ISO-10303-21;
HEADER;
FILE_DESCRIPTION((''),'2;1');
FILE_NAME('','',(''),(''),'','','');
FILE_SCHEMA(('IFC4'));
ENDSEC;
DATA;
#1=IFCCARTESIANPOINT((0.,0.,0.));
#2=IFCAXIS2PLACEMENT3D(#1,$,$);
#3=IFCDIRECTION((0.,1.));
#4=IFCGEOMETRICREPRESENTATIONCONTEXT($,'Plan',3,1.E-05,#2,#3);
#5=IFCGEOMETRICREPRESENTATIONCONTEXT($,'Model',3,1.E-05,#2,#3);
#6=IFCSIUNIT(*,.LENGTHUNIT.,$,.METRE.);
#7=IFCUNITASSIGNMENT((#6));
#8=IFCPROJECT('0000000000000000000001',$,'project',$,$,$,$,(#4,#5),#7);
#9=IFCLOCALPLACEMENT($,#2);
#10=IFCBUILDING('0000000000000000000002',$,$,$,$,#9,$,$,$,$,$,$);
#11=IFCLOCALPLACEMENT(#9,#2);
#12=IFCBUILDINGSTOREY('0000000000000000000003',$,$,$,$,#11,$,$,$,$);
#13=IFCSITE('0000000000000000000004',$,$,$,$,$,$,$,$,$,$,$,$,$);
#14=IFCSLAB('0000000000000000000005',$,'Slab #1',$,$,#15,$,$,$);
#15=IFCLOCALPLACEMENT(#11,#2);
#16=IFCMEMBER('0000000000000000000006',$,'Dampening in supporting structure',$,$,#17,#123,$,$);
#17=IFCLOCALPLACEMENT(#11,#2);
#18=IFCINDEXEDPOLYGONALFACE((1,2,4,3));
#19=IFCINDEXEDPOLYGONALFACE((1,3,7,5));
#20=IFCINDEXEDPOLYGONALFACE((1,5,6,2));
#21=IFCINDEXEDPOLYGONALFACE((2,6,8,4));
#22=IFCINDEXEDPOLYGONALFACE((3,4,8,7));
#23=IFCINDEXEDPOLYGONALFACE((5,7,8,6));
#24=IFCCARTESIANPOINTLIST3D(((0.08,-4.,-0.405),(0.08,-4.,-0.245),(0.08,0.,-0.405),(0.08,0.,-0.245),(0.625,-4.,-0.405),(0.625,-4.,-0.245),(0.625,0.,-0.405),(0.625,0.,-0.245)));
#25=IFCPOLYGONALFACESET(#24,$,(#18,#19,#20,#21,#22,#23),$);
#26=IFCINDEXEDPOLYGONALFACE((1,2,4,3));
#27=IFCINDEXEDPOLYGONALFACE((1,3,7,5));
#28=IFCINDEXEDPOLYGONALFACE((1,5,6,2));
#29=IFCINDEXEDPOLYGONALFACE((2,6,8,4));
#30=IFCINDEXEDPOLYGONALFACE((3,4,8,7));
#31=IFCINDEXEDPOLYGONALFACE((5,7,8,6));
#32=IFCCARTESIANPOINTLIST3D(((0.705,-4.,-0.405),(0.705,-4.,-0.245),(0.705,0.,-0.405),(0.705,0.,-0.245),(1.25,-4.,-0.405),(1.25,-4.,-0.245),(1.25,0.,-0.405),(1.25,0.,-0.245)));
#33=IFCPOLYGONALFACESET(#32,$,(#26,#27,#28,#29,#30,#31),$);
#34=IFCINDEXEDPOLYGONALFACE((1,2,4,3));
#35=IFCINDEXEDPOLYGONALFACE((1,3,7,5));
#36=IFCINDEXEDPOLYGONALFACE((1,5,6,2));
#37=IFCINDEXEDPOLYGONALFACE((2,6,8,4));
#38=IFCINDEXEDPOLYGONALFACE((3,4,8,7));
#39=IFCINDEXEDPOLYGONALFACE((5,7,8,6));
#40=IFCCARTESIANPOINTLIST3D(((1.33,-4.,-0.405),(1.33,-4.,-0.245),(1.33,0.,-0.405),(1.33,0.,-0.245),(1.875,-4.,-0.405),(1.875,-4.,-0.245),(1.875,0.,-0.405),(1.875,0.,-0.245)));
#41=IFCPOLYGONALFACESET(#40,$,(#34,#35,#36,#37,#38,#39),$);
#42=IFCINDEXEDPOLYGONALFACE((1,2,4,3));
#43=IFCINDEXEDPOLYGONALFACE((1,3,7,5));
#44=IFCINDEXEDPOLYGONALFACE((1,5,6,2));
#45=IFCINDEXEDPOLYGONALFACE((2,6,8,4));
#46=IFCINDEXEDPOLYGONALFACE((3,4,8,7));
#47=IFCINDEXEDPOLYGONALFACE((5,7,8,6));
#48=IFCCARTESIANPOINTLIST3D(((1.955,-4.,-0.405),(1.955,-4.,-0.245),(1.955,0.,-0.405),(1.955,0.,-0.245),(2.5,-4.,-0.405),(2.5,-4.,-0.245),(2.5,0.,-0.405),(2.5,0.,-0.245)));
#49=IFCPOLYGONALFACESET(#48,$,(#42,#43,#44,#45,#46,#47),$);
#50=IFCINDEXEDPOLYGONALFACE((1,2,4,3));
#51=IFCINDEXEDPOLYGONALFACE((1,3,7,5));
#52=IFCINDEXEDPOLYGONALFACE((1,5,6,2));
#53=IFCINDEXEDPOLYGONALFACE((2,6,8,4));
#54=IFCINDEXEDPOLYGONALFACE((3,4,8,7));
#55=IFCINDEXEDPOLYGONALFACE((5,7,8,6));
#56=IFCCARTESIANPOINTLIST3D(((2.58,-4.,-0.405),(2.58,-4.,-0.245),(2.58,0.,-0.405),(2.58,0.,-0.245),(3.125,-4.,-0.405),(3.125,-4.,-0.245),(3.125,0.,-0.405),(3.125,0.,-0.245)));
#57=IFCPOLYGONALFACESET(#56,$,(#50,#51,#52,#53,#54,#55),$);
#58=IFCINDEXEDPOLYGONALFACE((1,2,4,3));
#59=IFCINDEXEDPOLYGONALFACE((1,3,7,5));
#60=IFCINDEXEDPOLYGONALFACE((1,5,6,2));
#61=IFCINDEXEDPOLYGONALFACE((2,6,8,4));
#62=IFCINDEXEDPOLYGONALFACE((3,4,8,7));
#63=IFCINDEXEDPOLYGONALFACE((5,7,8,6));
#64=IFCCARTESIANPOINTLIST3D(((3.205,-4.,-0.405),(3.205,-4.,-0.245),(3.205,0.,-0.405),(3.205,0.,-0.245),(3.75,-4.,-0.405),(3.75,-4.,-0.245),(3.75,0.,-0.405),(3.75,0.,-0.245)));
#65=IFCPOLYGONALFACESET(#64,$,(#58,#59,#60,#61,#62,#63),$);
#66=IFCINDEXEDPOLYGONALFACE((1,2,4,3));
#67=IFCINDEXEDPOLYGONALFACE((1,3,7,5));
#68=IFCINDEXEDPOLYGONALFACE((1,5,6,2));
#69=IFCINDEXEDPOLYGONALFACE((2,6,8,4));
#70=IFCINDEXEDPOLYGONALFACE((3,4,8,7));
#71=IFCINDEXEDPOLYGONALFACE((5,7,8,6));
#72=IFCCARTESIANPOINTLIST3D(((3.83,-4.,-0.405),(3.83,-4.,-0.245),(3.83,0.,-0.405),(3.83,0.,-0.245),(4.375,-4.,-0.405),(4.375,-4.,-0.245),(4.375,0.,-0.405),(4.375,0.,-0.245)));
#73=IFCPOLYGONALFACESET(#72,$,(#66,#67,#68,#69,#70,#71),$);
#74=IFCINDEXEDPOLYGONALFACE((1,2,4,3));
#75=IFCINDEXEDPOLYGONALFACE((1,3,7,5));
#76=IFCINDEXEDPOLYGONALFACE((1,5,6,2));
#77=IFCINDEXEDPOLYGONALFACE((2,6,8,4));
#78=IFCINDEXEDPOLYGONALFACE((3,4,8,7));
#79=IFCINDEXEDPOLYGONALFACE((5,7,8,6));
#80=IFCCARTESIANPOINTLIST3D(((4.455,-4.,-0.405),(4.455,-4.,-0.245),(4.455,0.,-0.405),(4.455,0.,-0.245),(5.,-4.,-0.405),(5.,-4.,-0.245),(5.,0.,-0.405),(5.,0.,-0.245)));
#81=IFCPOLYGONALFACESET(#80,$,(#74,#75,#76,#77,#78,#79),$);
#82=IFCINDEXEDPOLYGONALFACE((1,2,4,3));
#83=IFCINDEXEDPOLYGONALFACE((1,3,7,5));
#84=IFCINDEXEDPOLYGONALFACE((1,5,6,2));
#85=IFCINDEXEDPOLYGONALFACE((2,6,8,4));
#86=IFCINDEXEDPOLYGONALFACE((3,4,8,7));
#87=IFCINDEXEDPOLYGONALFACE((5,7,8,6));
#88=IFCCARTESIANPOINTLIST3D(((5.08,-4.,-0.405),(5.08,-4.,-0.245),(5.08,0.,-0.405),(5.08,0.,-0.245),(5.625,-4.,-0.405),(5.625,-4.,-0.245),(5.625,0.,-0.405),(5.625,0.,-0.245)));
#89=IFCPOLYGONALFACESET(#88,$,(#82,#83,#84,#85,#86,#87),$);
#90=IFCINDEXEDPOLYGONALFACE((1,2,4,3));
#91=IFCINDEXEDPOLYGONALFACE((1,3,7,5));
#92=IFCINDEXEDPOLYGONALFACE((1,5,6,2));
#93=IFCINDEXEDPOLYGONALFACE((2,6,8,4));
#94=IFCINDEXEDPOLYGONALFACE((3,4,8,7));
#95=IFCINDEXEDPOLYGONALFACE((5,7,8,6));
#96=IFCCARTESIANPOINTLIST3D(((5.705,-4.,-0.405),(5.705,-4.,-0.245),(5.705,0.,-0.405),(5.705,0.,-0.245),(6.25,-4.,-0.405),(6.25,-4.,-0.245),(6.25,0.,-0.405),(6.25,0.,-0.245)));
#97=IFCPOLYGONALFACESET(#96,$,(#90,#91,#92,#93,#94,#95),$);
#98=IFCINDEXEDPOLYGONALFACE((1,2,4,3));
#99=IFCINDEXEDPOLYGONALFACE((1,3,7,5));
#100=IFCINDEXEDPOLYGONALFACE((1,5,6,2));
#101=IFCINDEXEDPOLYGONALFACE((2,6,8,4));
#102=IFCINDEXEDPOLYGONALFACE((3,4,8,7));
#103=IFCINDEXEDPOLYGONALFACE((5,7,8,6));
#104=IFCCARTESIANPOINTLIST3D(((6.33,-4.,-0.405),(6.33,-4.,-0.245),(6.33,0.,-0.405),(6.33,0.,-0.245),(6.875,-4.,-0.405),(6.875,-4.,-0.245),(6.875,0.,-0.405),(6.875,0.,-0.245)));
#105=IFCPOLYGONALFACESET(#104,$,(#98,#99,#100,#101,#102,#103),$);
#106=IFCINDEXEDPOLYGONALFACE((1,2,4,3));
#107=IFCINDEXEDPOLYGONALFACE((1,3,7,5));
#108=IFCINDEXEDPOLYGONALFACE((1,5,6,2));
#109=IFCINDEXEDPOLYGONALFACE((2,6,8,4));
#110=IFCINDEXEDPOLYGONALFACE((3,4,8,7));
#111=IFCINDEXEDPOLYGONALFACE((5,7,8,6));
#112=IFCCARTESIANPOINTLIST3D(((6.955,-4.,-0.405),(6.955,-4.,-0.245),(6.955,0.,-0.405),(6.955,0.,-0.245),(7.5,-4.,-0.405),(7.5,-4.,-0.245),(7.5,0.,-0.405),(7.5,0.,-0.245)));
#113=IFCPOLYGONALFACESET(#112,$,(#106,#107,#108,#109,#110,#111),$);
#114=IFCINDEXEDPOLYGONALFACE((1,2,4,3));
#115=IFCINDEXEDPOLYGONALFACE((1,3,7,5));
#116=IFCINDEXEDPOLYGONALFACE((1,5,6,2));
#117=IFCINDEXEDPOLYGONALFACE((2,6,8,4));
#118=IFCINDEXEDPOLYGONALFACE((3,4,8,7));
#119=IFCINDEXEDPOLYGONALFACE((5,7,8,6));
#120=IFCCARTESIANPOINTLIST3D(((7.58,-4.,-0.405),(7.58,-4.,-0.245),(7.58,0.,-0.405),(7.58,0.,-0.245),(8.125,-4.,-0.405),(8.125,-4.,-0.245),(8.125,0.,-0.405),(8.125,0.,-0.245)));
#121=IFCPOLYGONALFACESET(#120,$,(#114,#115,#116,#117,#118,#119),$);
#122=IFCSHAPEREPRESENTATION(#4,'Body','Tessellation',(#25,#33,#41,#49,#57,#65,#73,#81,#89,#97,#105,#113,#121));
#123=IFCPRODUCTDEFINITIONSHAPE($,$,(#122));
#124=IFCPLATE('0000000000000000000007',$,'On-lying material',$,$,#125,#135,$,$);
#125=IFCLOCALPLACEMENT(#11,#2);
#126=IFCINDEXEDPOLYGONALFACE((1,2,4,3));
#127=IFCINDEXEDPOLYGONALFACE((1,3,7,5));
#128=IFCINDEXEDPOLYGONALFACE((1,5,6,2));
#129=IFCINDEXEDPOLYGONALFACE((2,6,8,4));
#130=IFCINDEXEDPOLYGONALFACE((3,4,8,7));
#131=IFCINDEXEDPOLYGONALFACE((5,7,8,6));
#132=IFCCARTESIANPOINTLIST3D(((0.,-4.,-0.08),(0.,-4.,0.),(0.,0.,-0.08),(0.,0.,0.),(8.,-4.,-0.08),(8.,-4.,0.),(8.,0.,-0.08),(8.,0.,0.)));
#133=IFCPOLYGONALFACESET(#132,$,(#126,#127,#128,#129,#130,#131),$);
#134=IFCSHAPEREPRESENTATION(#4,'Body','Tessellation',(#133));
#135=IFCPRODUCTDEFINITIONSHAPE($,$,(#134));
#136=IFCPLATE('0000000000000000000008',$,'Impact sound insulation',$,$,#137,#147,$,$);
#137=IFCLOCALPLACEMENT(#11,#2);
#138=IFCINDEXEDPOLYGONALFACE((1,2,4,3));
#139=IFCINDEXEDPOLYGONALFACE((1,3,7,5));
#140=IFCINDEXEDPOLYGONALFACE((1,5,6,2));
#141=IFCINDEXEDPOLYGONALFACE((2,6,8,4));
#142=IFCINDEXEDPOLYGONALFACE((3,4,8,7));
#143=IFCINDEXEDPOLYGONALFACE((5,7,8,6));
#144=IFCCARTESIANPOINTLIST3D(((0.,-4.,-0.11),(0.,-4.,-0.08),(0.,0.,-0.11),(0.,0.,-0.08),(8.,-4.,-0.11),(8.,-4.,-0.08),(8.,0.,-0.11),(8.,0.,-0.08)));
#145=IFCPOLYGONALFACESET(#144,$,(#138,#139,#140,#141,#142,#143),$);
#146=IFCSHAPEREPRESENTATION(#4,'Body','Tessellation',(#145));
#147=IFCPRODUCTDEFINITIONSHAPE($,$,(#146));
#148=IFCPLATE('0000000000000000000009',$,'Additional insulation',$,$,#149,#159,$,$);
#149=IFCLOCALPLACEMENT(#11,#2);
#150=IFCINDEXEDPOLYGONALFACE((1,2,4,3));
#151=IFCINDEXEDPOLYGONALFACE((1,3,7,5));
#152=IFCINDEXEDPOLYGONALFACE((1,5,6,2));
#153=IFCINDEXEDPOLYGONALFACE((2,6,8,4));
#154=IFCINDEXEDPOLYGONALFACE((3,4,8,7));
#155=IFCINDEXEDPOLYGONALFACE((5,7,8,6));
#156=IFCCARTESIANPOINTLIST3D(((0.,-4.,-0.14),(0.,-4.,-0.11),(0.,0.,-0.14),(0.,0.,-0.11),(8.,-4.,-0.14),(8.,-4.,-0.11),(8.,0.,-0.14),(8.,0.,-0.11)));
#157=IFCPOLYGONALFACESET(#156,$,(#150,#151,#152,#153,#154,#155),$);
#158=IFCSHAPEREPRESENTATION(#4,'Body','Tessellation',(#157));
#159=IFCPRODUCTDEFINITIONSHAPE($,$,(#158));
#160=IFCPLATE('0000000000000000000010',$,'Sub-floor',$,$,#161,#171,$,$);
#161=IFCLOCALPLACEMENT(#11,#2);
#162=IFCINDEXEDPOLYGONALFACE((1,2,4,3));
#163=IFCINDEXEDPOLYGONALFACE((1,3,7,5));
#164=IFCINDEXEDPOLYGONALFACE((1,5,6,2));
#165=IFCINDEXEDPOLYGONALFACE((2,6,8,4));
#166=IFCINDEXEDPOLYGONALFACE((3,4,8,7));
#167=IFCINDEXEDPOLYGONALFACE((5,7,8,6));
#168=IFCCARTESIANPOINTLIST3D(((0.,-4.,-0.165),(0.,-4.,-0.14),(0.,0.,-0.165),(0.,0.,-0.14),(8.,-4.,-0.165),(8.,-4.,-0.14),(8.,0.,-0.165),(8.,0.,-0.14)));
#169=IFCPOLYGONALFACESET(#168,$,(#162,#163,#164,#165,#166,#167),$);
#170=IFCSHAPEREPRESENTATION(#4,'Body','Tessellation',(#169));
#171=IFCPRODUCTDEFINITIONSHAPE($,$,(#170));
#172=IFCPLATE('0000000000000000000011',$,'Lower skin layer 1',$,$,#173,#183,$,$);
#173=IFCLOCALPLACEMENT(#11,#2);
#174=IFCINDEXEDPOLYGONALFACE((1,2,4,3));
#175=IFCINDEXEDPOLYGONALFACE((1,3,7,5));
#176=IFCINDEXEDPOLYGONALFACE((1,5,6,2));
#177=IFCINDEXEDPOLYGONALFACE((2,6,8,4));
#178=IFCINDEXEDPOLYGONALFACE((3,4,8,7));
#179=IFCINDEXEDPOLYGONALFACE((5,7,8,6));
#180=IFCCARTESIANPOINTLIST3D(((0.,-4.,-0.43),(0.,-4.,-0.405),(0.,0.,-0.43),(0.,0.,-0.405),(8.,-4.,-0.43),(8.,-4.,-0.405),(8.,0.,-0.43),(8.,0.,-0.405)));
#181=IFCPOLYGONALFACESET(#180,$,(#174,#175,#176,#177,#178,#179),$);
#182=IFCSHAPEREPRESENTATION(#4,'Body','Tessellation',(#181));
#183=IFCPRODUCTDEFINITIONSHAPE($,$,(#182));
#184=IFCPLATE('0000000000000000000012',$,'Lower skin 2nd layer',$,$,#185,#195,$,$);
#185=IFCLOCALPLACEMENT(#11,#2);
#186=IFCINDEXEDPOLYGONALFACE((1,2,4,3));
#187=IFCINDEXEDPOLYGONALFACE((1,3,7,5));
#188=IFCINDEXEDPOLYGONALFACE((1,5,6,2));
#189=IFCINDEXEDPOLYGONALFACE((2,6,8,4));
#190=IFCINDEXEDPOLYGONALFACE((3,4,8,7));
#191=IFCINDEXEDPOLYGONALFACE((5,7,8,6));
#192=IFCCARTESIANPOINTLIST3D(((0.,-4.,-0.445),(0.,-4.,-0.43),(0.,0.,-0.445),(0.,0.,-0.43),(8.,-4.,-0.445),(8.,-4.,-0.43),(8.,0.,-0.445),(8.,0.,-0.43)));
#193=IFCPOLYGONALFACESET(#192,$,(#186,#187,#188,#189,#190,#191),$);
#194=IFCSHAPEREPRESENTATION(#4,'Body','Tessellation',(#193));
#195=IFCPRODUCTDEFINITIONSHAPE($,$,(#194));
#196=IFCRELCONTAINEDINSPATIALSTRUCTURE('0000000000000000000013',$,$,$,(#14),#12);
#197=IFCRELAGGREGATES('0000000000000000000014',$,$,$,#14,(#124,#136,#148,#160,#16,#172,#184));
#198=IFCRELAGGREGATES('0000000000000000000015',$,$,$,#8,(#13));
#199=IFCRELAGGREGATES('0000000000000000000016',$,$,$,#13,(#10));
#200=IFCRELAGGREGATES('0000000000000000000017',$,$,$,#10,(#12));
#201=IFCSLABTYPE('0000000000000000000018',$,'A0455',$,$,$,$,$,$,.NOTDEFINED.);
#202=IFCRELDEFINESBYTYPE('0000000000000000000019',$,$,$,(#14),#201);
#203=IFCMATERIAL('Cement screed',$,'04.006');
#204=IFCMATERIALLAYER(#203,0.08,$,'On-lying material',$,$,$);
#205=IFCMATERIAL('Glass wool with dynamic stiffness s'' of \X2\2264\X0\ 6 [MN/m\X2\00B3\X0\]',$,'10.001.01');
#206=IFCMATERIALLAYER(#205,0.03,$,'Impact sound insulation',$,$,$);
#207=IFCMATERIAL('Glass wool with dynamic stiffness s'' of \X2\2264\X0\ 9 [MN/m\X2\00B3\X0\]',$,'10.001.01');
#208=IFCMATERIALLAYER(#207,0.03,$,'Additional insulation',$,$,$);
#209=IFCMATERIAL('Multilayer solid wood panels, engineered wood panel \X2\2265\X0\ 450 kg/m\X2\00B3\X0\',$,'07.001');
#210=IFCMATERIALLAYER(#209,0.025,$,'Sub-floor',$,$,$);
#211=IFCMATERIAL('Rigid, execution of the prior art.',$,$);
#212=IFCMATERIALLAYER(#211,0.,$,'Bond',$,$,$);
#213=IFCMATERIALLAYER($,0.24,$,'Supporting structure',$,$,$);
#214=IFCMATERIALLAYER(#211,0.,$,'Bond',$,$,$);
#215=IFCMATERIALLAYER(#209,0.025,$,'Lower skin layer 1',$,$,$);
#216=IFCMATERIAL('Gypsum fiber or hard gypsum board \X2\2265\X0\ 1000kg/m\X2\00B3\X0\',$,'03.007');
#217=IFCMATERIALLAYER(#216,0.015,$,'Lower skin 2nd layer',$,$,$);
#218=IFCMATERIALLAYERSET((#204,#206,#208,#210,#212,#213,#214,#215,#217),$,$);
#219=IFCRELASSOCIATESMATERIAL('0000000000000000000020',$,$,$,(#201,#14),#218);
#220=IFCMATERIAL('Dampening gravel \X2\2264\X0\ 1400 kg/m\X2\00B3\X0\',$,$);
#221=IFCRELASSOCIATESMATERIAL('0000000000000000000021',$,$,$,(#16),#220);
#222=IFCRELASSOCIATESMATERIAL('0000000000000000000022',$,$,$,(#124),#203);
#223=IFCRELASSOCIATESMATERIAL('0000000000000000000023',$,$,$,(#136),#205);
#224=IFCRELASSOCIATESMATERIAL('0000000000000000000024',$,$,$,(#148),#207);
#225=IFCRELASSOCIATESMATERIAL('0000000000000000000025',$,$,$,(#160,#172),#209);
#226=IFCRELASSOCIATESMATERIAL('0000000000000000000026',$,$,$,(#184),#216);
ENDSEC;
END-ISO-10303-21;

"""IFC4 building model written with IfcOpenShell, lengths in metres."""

from ifc_helpers import new_model, si_unit, direction, frame, frame_2d, origin, origin_with_axes, place, context, project, spatial, rectangle, extrude, material, layer, layer_set, type_object, element, aggregate, save


model = new_model("IFC4")

# Units and contexts
plan_context = context("Plan", 3, precision=1e-05, world=origin(), true_north=direction((0.0, 1.0)))
model_context = context("Model", 3, precision=1e-05, world=origin(), true_north=direction((0.0, 1.0)))
ifc_project = project(units=[si_unit("LENGTHUNIT", "METRE")], contexts=[plan_context, model_context])

# Site, building, storey
site = spatial("IfcSite", under=ifc_project)
building_placement = place(None, origin())
building = spatial("IfcBuilding", under=site, at=building_placement)
storey_placement = place(building_placement, origin())
storey = spatial("IfcBuildingStorey", under=building, at=storey_placement)

# Slab, member, plates
ifc_material_1 = material(Name="Cement screed", Category="04.006")
ifc_layer_1 = layer(ifc_material_1, 0.08, Name="On-lying material")
ifc_material_2 = material(Name="Glass wool with dynamic stiffness s' of ≤ 6 [MN/m³]", Category="10.001.01")
ifc_layer_2 = layer(ifc_material_2, 0.03, Name="Impact sound insulation")
ifc_material_3 = material(Name="Glass wool with dynamic stiffness s' of ≤ 9 [MN/m³]", Category="10.001.01")
ifc_layer_3 = layer(ifc_material_3, 0.03, Name="Additional insulation")
ifc_material_4 = material(Name="Multilayer solid wood panels, engineered wood panel ≥ 450 kg/m³", Category="07.001")
ifc_layer_4 = layer(ifc_material_4, 0.025, Name="Sub-floor")
ifc_material_5 = material(Name="Rigid, execution of the prior art.")
ifc_layer_5 = layer(ifc_material_5, 0.0, Name="Bond")
ifc_layer_6 = layer(None, 0.24, Name="Supporting structure")
ifc_layer_7 = layer(ifc_material_5, 0.0, Name="Bond")
ifc_layer_8 = layer(ifc_material_4, 0.025, Name="Lower skin layer 1")
ifc_material_6 = material(Name="Gypsum fiber or hard gypsum board ≥ 1000kg/m³", Category="03.007")
ifc_layer_9 = layer(ifc_material_6, 0.015, Name="Lower skin 2nd layer")
ifc_layer_set = layer_set([ifc_layer_1, ifc_layer_2, ifc_layer_3, ifc_layer_4, ifc_layer_5, ifc_layer_6, ifc_layer_7, ifc_layer_8, ifc_layer_9])
slab_type = type_object("IfcSlabType", Name="A0455", PredefinedType="NOTDEFINED", material=ifc_layer_set)
slab_placement = place(None, frame((0.0, 0.0, 0.0), z_axis=(0.0, 0.0, -1.0), x_axis=(1.0, 0.0, 0.0)))
slab = element("IfcSlab", 1, at=slab_placement, inside=storey, type_object=slab_type, material=ifc_layer_set, Name="Slab #1")
ifc_material_7 = material(Name="Dampening gravel ≤ 1400 kg/m³")
member_1_placement = place(slab_placement, origin())
member_1 = element("IfcMember", 2, at=member_1_placement, material=ifc_material_7, Name="Dampening in supporting structure", context=plan_context, shape_type="SweptSolid", body=[
    extrude(rectangle(XDim=0.545, YDim=0.16, at=frame_2d((0.2725, 0.08), x_axis=(1.0, 0.0))), frame((0.08, 4.0, 0.245), z_axis=(0.0, -1.0, 0.0), x_axis=(1.0, 0.0, 0.0)), (0.0, 0.0, 1.0), 4.0),
    extrude(rectangle(XDim=0.545, YDim=0.16, at=frame_2d((0.2725, 0.08), x_axis=(1.0, 0.0))), frame((0.705, 4.0, 0.245), z_axis=(0.0, -1.0, 0.0), x_axis=(1.0, 0.0, 0.0)), (0.0, 0.0, 1.0), 4.0),
    extrude(rectangle(XDim=0.545, YDim=0.16, at=frame_2d((0.2725, 0.08), x_axis=(1.0, 0.0))), frame((1.33, 4.0, 0.245), z_axis=(0.0, -1.0, 0.0), x_axis=(1.0, 0.0, 0.0)), (0.0, 0.0, 1.0), 4.0),
    extrude(rectangle(XDim=0.545, YDim=0.16, at=frame_2d((0.2725, 0.08), x_axis=(1.0, 0.0))), frame((1.955, 4.0, 0.245), z_axis=(0.0, -1.0, 0.0), x_axis=(1.0, 0.0, 0.0)), (0.0, 0.0, 1.0), 4.0),
    extrude(rectangle(XDim=0.545, YDim=0.16, at=frame_2d((0.2725, 0.08), x_axis=(1.0, 0.0))), frame((2.58, 4.0, 0.245), z_axis=(0.0, -1.0, 0.0), x_axis=(1.0, 0.0, 0.0)), (0.0, 0.0, 1.0), 4.0),
    extrude(rectangle(XDim=0.545, YDim=0.16, at=frame_2d((0.2725, 0.08), x_axis=(1.0, 0.0))), frame((3.205, 4.0, 0.245), z_axis=(0.0, -1.0, 0.0), x_axis=(1.0, 0.0, 0.0)), (0.0, 0.0, 1.0), 4.0),
    extrude(rectangle(XDim=0.545, YDim=0.16, at=frame_2d((0.2725, 0.08), x_axis=(1.0, 0.0))), frame((3.83, 4.0, 0.245), z_axis=(0.0, -1.0, 0.0), x_axis=(1.0, 0.0, 0.0)), (0.0, 0.0, 1.0), 4.0),
    extrude(rectangle(XDim=0.545, YDim=0.16, at=frame_2d((0.2725, 0.08), x_axis=(1.0, 0.0))), frame((4.455, 4.0, 0.245), z_axis=(0.0, -1.0, 0.0), x_axis=(1.0, 0.0, 0.0)), (0.0, 0.0, 1.0), 4.0),
    extrude(rectangle(XDim=0.545, YDim=0.16, at=frame_2d((0.2725, 0.08), x_axis=(1.0, 0.0))), frame((5.08, 4.0, 0.245), z_axis=(0.0, -1.0, 0.0), x_axis=(1.0, 0.0, 0.0)), (0.0, 0.0, 1.0), 4.0),
    extrude(rectangle(XDim=0.545, YDim=0.16, at=frame_2d((0.2725, 0.08), x_axis=(1.0, 0.0))), frame((5.705, 4.0, 0.245), z_axis=(0.0, -1.0, 0.0), x_axis=(1.0, 0.0, 0.0)), (0.0, 0.0, 1.0), 4.0),
    extrude(rectangle(XDim=0.545, YDim=0.16, at=frame_2d((0.2725, 0.08), x_axis=(1.0, 0.0))), frame((6.33, 4.0, 0.245), z_axis=(0.0, -1.0, 0.0), x_axis=(1.0, 0.0, 0.0)), (0.0, 0.0, 1.0), 4.0),
    extrude(rectangle(XDim=0.545, YDim=0.16, at=frame_2d((0.2725, 0.08), x_axis=(1.0, 0.0))), frame((6.955, 4.0, 0.245), z_axis=(0.0, -1.0, 0.0), x_axis=(1.0, 0.0, 0.0)), (0.0, 0.0, 1.0), 4.0),
    extrude(rectangle(XDim=0.545, YDim=0.16, at=frame_2d((0.2725, 0.08), x_axis=(1.0, 0.0))), frame((7.58, 4.0, 0.245), z_axis=(0.0, -1.0, 0.0), x_axis=(1.0, 0.0, 0.0)), (0.0, 0.0, 1.0), 4.0),
])
plate_1_placement = place(slab_placement, origin())
plate_1 = element("IfcPlate", 3, at=plate_1_placement, material=ifc_material_1, Name="On-lying material", context=plan_context, shape_type="SweptSolid", body=[
    extrude(rectangle(XDim=8.0, YDim=4.0, at=frame_2d((4.0, 2.0), x_axis=(1.0, 0.0))), origin_with_axes(), (0.0, 0.0, 1.0), 0.08),
])
plate_2_placement = place(slab_placement, origin())
plate_2 = element("IfcPlate", 4, at=plate_2_placement, material=ifc_material_2, Name="Impact sound insulation", context=plan_context, shape_type="SweptSolid", body=[
    extrude(rectangle(XDim=8.0, YDim=4.0, at=frame_2d((4.0, 2.0), x_axis=(1.0, 0.0))), frame((0.0, 0.0, 0.08), z_axis=(0.0, 0.0, 1.0), x_axis=(1.0, 0.0, 0.0)), (0.0, 0.0, 1.0), 0.03),
])
plate_3_placement = place(slab_placement, origin())
plate_3 = element("IfcPlate", 5, at=plate_3_placement, material=ifc_material_3, Name="Additional insulation", context=plan_context, shape_type="SweptSolid", body=[
    extrude(rectangle(XDim=8.0, YDim=4.0, at=frame_2d((4.0, 2.0), x_axis=(1.0, 0.0))), frame((0.0, 0.0, 0.11), z_axis=(0.0, 0.0, 1.0), x_axis=(1.0, 0.0, 0.0)), (0.0, 0.0, 1.0), 0.03),
])
plate_4_placement = place(slab_placement, origin())
plate_4 = element("IfcPlate", 6, at=plate_4_placement, material=ifc_material_4, Name="Sub-floor", context=plan_context, shape_type="SweptSolid", body=[
    extrude(rectangle(XDim=8.0, YDim=4.0, at=frame_2d((4.0, 2.0), x_axis=(1.0, 0.0))), frame((0.0, 0.0, 0.14), z_axis=(0.0, 0.0, 1.0), x_axis=(1.0, 0.0, 0.0)), (0.0, 0.0, 1.0), 0.025),
])
plate_5_placement = place(slab_placement, origin())
plate_5 = element("IfcPlate", 7, at=plate_5_placement, material=ifc_material_4, Name="Lower skin layer 1", context=plan_context, shape_type="SweptSolid", body=[
    extrude(rectangle(XDim=8.0, YDim=4.0, at=frame_2d((4.0, 2.0), x_axis=(1.0, 0.0))), frame((0.0, 0.0, 0.405), z_axis=(0.0, 0.0, 1.0), x_axis=(1.0, 0.0, 0.0)), (0.0, 0.0, 1.0), 0.025),
])
plate_6_placement = place(slab_placement, origin())
plate_6 = element("IfcPlate", 8, at=plate_6_placement, material=ifc_material_6, Name="Lower skin 2nd layer", context=plan_context, shape_type="SweptSolid", body=[
    extrude(rectangle(XDim=8.0, YDim=4.0, at=frame_2d((4.0, 2.0), x_axis=(1.0, 0.0))), frame((0.0, 0.0, 0.43), z_axis=(0.0, 0.0, 1.0), x_axis=(1.0, 0.0, 0.0)), (0.0, 0.0, 1.0), 0.015),
])
aggregate(slab, [plate_1, plate_2, plate_3, plate_4, member_1, plate_5, plate_6])

save(model, "model.ifc")
